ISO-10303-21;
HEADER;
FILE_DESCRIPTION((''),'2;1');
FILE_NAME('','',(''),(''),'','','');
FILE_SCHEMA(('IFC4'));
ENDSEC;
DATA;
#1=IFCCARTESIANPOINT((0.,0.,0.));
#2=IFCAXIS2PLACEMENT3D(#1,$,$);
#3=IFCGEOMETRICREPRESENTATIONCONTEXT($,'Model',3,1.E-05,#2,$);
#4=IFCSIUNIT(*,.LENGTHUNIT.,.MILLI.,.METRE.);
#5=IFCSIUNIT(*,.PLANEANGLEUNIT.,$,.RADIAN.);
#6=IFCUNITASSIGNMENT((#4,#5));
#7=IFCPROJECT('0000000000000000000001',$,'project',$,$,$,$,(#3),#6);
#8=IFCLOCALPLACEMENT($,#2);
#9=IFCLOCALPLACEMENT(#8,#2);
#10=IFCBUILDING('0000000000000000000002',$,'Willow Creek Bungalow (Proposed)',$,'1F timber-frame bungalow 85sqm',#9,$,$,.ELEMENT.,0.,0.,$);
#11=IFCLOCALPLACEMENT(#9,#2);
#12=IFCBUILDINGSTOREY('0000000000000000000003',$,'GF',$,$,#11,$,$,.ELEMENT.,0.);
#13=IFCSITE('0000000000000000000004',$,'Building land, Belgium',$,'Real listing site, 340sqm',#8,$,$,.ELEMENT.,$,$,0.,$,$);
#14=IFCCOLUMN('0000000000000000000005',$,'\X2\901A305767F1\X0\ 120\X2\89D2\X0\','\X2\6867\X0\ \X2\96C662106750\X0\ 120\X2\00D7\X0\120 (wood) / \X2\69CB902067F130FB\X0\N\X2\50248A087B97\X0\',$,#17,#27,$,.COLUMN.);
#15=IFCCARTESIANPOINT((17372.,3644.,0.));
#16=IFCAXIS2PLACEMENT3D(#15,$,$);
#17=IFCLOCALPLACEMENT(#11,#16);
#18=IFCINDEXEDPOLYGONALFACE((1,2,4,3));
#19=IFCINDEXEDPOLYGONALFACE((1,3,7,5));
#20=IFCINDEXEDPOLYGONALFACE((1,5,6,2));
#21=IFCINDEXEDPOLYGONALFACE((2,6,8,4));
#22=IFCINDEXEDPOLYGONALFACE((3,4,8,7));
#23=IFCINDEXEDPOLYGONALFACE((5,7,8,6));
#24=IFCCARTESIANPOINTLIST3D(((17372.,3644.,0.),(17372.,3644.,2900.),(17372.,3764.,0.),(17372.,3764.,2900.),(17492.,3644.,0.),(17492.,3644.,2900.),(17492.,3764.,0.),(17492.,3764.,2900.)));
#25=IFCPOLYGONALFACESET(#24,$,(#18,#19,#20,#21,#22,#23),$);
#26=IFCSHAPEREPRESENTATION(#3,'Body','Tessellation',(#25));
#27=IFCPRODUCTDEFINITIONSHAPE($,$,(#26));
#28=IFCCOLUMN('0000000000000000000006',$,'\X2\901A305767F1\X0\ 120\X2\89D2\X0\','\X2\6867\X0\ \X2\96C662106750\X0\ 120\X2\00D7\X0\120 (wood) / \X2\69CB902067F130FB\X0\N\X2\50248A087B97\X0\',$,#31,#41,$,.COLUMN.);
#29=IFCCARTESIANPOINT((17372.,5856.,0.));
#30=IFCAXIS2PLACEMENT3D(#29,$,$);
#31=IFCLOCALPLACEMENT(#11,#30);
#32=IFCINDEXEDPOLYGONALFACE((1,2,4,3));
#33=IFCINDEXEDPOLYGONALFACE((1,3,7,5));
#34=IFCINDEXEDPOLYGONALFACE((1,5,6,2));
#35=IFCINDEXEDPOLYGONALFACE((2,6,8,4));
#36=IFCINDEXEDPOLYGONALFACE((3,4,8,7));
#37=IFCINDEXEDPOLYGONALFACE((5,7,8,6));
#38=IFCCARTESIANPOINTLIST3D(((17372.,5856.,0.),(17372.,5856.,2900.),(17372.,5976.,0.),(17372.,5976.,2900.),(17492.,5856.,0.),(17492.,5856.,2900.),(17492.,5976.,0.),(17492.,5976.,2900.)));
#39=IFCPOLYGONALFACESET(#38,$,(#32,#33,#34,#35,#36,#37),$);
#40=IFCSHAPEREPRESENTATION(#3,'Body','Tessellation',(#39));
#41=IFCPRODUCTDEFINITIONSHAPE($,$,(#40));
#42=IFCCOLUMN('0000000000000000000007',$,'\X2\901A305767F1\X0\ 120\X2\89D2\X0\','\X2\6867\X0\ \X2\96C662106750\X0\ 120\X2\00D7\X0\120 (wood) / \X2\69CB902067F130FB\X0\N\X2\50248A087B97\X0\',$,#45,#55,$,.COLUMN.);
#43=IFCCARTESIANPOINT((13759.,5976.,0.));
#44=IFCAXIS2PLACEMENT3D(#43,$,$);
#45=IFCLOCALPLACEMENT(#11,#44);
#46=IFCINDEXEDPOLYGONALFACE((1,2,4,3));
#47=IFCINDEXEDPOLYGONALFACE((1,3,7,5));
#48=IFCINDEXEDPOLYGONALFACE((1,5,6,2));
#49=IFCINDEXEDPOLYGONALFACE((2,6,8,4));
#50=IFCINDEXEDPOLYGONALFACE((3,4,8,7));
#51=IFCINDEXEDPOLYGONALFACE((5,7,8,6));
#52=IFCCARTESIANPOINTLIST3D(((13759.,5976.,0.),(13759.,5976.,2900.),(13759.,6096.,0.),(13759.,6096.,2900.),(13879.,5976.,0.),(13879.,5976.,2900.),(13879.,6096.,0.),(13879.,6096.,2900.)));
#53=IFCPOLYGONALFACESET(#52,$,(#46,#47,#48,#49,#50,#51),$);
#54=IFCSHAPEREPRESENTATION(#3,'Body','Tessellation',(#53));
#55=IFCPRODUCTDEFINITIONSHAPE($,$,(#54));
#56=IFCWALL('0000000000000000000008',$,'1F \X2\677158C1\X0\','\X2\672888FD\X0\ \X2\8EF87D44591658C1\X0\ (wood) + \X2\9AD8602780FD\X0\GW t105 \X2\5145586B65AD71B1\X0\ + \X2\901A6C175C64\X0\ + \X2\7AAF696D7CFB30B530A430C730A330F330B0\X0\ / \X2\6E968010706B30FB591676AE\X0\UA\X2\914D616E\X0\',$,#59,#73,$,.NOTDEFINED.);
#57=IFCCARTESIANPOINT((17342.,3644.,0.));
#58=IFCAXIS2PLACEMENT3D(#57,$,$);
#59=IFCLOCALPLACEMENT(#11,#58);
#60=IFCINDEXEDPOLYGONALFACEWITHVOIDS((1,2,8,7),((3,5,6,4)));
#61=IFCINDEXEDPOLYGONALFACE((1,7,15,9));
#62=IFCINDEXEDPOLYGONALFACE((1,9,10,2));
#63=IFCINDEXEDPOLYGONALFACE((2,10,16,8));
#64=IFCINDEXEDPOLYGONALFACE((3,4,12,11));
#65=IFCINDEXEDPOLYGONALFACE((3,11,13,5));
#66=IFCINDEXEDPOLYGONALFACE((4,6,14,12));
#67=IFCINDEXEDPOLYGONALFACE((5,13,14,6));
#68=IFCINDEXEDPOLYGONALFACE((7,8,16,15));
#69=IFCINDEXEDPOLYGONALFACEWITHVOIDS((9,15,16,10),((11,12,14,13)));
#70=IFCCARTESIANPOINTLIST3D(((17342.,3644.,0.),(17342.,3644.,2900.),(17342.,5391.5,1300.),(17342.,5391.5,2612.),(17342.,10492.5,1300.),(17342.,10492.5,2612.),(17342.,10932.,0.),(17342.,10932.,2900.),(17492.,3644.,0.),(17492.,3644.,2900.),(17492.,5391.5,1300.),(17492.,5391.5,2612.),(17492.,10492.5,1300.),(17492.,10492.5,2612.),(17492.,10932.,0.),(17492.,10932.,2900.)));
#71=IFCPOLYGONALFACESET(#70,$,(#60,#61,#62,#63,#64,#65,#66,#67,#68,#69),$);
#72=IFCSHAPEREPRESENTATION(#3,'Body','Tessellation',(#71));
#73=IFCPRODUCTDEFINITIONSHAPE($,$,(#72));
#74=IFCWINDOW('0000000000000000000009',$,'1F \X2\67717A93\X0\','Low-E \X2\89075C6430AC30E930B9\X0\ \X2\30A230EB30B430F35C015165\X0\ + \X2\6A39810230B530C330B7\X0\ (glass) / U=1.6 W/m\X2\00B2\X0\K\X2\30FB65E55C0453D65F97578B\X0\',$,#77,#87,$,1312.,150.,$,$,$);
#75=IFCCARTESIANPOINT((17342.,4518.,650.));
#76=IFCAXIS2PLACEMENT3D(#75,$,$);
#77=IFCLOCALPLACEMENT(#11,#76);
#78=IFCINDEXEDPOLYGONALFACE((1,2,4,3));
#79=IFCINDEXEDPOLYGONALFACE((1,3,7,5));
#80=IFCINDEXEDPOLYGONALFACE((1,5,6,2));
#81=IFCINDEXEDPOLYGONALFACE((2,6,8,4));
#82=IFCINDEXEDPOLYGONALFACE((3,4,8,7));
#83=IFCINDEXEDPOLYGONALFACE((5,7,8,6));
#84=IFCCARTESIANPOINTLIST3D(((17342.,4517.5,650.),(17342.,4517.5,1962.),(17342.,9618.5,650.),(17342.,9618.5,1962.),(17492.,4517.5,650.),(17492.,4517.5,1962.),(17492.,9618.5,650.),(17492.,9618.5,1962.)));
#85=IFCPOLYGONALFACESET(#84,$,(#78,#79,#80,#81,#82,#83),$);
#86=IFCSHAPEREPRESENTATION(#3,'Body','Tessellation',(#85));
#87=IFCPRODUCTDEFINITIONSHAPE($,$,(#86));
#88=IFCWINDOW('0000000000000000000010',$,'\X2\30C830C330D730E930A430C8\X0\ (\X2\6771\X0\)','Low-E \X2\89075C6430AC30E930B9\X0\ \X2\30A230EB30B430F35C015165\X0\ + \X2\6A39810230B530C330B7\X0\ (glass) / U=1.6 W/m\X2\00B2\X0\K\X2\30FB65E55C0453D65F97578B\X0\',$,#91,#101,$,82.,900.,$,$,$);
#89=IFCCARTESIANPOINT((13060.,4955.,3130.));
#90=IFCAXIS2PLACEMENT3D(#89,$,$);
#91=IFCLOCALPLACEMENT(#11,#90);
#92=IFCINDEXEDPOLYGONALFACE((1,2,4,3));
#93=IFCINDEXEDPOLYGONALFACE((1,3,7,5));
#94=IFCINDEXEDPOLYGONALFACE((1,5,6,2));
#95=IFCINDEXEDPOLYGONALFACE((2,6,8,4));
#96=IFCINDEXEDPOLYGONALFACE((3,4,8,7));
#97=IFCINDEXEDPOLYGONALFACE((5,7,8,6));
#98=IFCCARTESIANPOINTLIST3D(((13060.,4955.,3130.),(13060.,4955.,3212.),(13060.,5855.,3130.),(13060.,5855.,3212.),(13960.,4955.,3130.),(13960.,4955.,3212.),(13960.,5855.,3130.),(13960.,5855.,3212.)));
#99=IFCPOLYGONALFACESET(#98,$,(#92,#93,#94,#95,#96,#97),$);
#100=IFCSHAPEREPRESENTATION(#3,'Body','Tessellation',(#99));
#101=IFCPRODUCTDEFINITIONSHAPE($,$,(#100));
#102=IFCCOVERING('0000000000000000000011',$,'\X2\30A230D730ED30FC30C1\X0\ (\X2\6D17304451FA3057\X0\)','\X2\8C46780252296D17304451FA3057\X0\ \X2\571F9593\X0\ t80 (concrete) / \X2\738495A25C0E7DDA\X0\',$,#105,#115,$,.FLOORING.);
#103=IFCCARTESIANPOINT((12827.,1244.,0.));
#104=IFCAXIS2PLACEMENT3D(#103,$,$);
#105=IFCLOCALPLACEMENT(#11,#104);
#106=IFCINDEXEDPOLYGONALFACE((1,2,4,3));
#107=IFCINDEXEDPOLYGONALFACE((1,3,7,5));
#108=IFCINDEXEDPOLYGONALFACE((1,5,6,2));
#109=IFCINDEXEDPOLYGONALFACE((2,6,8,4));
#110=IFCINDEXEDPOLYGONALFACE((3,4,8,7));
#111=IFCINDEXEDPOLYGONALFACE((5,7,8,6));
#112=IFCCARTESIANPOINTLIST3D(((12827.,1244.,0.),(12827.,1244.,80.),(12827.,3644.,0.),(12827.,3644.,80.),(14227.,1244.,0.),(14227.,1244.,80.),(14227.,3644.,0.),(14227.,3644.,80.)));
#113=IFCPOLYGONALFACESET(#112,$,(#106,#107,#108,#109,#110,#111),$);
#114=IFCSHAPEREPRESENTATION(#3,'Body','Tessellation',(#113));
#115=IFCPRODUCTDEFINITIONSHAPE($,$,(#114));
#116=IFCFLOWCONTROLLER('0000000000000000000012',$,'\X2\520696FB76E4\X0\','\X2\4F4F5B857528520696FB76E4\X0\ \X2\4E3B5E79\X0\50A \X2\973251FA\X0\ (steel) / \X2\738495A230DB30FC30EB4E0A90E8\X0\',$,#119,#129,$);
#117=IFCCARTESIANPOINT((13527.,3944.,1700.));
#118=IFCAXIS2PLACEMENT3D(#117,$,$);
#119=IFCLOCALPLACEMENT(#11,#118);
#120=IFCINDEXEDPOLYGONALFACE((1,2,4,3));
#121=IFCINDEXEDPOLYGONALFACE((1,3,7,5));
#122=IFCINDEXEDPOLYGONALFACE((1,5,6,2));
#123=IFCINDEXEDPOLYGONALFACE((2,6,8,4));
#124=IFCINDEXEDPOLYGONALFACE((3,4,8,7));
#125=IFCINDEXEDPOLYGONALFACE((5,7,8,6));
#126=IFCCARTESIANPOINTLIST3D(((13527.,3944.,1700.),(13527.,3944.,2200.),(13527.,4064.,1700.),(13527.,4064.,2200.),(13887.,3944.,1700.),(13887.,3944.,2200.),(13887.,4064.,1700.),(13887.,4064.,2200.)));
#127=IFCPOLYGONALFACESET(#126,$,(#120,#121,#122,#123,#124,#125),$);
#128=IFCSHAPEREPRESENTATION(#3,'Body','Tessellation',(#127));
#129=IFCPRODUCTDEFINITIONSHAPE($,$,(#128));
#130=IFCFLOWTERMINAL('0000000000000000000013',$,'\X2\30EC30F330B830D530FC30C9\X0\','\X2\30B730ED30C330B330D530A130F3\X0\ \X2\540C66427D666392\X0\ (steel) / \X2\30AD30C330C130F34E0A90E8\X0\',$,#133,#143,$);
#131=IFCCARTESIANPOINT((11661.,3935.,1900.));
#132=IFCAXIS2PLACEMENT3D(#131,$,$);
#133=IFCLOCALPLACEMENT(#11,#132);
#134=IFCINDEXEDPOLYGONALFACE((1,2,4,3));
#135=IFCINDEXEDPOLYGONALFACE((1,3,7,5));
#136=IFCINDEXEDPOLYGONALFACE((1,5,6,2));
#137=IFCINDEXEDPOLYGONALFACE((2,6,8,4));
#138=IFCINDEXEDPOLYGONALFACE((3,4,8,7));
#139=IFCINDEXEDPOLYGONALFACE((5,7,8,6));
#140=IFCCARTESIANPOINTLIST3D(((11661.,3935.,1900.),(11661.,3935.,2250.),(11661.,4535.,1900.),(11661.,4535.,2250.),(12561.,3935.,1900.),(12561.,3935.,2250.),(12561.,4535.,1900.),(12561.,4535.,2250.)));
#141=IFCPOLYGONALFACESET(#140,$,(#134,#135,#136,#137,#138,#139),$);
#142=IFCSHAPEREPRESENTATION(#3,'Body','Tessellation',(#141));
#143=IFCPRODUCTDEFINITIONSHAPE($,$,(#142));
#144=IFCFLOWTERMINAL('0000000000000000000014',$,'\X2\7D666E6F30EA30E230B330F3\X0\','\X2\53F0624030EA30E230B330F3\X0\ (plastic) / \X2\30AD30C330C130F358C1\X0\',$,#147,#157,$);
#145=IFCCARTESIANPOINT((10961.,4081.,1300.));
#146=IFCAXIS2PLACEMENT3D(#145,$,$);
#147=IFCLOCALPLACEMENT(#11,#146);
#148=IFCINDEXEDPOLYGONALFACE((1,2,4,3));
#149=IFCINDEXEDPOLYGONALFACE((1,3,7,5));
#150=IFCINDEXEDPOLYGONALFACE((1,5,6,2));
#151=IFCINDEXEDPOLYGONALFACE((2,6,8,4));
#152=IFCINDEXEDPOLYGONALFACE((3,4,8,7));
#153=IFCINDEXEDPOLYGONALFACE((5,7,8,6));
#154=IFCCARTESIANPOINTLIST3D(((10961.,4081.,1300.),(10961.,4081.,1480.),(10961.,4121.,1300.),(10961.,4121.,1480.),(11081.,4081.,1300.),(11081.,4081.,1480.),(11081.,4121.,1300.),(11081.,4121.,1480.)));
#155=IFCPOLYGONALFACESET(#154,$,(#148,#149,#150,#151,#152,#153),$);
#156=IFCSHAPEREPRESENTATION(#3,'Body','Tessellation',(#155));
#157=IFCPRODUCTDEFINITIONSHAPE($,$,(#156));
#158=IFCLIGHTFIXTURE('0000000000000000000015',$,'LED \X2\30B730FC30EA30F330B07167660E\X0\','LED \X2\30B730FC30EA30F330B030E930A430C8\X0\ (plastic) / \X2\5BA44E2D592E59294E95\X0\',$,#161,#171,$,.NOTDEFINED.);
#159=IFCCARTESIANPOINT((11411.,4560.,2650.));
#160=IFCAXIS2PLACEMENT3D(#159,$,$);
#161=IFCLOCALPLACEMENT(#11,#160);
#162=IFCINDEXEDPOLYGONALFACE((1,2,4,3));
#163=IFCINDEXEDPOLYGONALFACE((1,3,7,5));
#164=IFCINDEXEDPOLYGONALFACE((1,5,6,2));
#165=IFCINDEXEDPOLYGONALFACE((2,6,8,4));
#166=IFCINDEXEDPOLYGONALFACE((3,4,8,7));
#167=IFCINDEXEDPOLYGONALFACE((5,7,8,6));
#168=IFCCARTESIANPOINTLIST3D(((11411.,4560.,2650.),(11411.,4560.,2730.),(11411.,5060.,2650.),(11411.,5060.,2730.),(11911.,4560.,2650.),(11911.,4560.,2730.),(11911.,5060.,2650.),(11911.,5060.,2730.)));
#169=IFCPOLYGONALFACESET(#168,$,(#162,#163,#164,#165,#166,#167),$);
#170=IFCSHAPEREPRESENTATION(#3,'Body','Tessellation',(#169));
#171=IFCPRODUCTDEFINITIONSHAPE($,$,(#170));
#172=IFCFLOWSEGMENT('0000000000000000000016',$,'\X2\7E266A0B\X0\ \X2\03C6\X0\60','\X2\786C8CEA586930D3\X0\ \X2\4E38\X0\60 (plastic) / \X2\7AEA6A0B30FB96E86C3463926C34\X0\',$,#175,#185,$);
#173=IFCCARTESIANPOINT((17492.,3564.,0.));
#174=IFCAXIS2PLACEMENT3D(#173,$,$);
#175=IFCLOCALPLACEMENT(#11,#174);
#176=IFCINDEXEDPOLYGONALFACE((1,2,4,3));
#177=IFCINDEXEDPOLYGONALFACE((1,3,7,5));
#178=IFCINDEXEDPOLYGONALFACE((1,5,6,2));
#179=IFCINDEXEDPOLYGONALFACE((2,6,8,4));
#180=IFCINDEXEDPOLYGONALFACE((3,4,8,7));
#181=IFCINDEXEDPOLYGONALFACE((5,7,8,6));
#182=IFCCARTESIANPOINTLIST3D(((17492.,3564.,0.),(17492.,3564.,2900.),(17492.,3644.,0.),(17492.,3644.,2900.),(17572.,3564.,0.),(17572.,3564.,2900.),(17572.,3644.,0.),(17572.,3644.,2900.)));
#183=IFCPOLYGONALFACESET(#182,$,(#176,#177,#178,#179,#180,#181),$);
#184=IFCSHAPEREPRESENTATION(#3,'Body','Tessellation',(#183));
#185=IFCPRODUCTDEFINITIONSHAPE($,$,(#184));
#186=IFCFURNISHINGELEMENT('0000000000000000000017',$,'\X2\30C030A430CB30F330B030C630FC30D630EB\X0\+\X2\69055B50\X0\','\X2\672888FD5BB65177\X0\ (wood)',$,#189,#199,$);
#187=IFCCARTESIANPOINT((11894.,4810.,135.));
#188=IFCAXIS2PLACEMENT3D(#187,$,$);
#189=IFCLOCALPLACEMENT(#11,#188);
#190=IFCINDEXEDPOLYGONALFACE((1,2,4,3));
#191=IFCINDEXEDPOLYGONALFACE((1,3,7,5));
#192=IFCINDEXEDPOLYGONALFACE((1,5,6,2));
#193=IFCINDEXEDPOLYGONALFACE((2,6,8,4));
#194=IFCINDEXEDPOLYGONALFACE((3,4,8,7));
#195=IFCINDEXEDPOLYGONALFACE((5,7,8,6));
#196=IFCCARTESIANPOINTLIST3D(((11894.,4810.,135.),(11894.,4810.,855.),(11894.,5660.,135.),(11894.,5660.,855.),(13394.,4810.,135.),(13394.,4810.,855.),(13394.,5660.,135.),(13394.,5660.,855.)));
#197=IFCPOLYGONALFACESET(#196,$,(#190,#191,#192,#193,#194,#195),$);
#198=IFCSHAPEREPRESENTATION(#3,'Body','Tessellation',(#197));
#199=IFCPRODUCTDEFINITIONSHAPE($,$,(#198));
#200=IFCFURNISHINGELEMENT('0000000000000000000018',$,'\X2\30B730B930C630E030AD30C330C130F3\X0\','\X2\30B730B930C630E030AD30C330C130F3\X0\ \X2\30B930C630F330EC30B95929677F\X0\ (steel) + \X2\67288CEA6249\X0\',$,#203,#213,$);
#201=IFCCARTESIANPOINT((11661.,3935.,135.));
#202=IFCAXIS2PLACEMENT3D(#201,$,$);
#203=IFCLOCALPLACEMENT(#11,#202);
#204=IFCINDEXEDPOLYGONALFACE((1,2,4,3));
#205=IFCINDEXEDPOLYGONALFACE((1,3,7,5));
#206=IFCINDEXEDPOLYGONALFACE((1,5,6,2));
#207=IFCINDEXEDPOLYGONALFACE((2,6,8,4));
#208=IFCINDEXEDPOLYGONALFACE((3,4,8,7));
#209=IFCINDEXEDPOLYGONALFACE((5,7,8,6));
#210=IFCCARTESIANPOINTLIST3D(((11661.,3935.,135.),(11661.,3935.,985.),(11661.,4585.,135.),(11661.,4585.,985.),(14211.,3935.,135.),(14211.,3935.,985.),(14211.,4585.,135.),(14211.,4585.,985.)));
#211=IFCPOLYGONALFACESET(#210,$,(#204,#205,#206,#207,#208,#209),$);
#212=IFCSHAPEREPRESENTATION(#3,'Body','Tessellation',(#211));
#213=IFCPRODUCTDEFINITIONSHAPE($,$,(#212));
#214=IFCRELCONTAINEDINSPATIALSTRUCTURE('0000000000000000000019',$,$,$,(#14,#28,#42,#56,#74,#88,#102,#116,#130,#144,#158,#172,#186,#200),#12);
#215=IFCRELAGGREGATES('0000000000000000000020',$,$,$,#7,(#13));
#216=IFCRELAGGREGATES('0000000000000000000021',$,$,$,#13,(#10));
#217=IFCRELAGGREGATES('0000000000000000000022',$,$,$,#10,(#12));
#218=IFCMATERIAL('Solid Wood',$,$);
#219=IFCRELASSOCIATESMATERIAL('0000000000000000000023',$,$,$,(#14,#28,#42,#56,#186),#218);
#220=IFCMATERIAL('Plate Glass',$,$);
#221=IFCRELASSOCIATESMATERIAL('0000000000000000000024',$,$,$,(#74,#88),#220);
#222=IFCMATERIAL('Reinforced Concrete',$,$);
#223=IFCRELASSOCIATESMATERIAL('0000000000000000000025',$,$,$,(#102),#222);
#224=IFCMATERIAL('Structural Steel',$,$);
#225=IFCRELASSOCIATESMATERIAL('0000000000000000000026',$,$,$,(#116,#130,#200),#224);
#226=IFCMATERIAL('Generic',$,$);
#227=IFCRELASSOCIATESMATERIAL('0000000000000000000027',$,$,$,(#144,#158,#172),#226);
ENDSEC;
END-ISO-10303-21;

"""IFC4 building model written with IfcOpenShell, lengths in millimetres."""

from ifc_helpers import new_model, si_unit, frame, frame_2d, origin, place, context, project, spatial, rectangle, extrude, material, element, fill, save


model = new_model("IFC4")

# Units and contexts
model_context = context("Model", 3, precision=1e-05, world=origin())
ifc_project = project(units=[si_unit("LENGTHUNIT", "METRE", prefix="MILLI"), si_unit("PLANEANGLEUNIT", "RADIAN")], contexts=[model_context])

# Site, building, storey
site_placement = place(None, origin())
site = spatial("IfcSite", under=ifc_project, at=site_placement, Name="Building land, Belgium", ObjectType="Real listing site, 340sqm", CompositionType="ELEMENT", RefElevation=0.0)
building_placement = place(site_placement, origin())
building = spatial("IfcBuilding", under=site, at=building_placement, Name="Willow Creek Bungalow (Proposed)", ObjectType="1F timber-frame bungalow 85sqm", CompositionType="ELEMENT", ElevationOfRefHeight=0.0, ElevationOfTerrain=0.0)
storey_placement = place(building_placement, origin())
storey = spatial("IfcBuildingStorey", under=building, at=storey_placement, Name="GF", CompositionType="ELEMENT", Elevation=0.0)

# Columns
ifc_material_1 = material(Name="Solid Wood")
column_1_placement = place(storey_placement, frame((17372.0, 3644.0, 0.0)))
element("IfcColumn", 1, at=column_1_placement, inside=storey, material=ifc_material_1, Name="通し柱 120角", Description="桧 集成材 120×120 (wood) / 構造柱・N値計算", PredefinedType="COLUMN", context=model_context, shape_type="SweptSolid", body=[
    extrude(rectangle(XDim=120.0, YDim=120.0, at=frame_2d((60.0, 60.0))), frame((17372.0, 3644.0, 0.0)), (0.0, 0.0, 1.0), 2900.0),
])
column_2_placement = place(storey_placement, frame((17372.0, 5856.0, 0.0)))
element("IfcColumn", 2, at=column_2_placement, inside=storey, material=ifc_material_1, Name="通し柱 120角", Description="桧 集成材 120×120 (wood) / 構造柱・N値計算", PredefinedType="COLUMN", context=model_context, shape_type="SweptSolid", body=[
    extrude(rectangle(XDim=120.0, YDim=120.0, at=frame_2d((60.0, 60.0))), frame((17372.0, 5856.0, 0.0)), (0.0, 0.0, 1.0), 2900.0),
])
column_3_placement = place(storey_placement, frame((13759.0, 5976.0, 0.0)))
element("IfcColumn", 3, at=column_3_placement, inside=storey, material=ifc_material_1, Name="通し柱 120角", Description="桧 集成材 120×120 (wood) / 構造柱・N値計算", PredefinedType="COLUMN", context=model_context, shape_type="SweptSolid", body=[
    extrude(rectangle(XDim=120.0, YDim=120.0, at=frame_2d((60.0, 60.0))), frame((13759.0, 5976.0, 0.0)), (0.0, 0.0, 1.0), 2900.0),
])

# Wall, opening, window
wall_1_placement = place(storey_placement, frame((17342.0, 3644.0, 0.0)))
wall_1 = element("IfcWall", 4, at=wall_1_placement, inside=storey, material=ifc_material_1, Name="1F 東壁", Description="木製 軸組外壁 (wood) + 高性能GW t105 充填断熱 + 通気層 + 窯業系サイディング / 準耐火・外皮UA配慮", PredefinedType="NOTDEFINED", context=model_context, shape_type="SweptSolid", body=[
    extrude(rectangle(XDim=150.0, YDim=7288.0, at=frame_2d((75.0, 3644.0))), frame((17342.0, 3644.0, 0.0)), (0.0, 0.0, 1.0), 2900.0),
])
opening_1_placement = place(storey_placement, frame((17342.0, 4518.0, 650.0)))
opening_1 = element("IfcOpeningElement", 5, at=opening_1_placement, cuts=wall_1, PredefinedType="NOTDEFINED", context=model_context, shape_type="SweptSolid", body=[
    extrude(rectangle(XDim=150.0, YDim=5101.0, at=frame_2d((75.0, 2550.0))), frame((17342.0, 4518.0, 650.0)), (0.0, 0.0, 1.0), 1312.0),
])
ifc_material_2 = material(Name="Plate Glass")
window_1_placement = place(storey_placement, frame((17342.0, 4518.0, 650.0)))
window_1 = element("IfcWindow", 6, at=window_1_placement, inside=storey, material=ifc_material_2, Name="1F 東窓", Description="Low-E 複層ガラス アルゴン封入 + 樹脂サッシ (glass) / U=1.6 W/m²K・日射取得型", OverallHeight=1312.0, OverallWidth=150.0, context=model_context, shape_type="SweptSolid", body=[
    extrude(rectangle(XDim=150.0, YDim=5101.0, at=frame_2d((75.0, 2550.0))), frame((17342.0, 4518.0, 650.0)), (0.0, 0.0, 1.0), 1312.0),
])
fill(opening_1, window_1)

# Window
window_2_placement = place(storey_placement, frame((13060.0, 4955.0, 3130.0)))
element("IfcWindow", 7, at=window_2_placement, inside=storey, material=ifc_material_2, Name="トップライト (東)", Description="Low-E 複層ガラス アルゴン封入 + 樹脂サッシ (glass) / U=1.6 W/m²K・日射取得型", OverallHeight=82.0, OverallWidth=900.0, context=model_context, shape_type="SweptSolid", body=[
    extrude(rectangle(XDim=900.0, YDim=900.0, at=frame_2d((450.0, 450.0))), frame((13060.0, 4955.0, 3130.0)), (0.0, 0.0, 1.0), 82.0),
])

# Shared definitions
ifc_material_3 = material(Name="Structural Steel")

# Covering
ifc_material_4 = material(Name="Reinforced Concrete")
covering_placement = place(storey_placement, frame((12827.0, 1244.0, 0.0)))
element("IfcCovering", 8, at=covering_placement, inside=storey, material=ifc_material_4, Name="アプローチ (洗い出し)", Description="豆砂利洗い出し 土間 t80 (concrete) / 玄関導線", PredefinedType="FLOORING", context=model_context, shape_type="SweptSolid", body=[
    extrude(rectangle(XDim=1400.0, YDim=2400.0, at=frame_2d((700.0, 1200.0))), frame((12827.0, 1244.0, 0.0)), (0.0, 0.0, 1.0), 80.0),
])

# Flow controller
flow_controller_placement = place(storey_placement, frame((13527.0, 3944.0, 1700.0)))
element("IfcFlowController", 9, at=flow_controller_placement, inside=storey, material=ifc_material_3, Name="分電盤", Description="住宅用分電盤 主幹50A 露出 (steel) / 玄関ホール上部", context=model_context, shape_type="SweptSolid", body=[
    extrude(rectangle(XDim=360.0, YDim=120.0, at=frame_2d((180.0, 60.0))), frame((13527.0, 3944.0, 1700.0)), (0.0, 0.0, 1.0), 500.0),
])

# Flow terminals
flow_terminal_1_placement = place(storey_placement, frame((11661.0, 3935.0, 1900.0)))
element("IfcFlowTerminal", 10, at=flow_terminal_1_placement, inside=storey, material=ifc_material_3, Name="レンジフード", Description="シロッコファン 同時給排 (steel) / キッチン上部", context=model_context, shape_type="SweptSolid", body=[
    extrude(rectangle(XDim=900.0, YDim=600.0, at=frame_2d((450.0, 300.0))), frame((11661.0, 3935.0, 1900.0)), (0.0, 0.0, 1.0), 350.0),
])
ifc_material_5 = material(Name="Generic")
flow_terminal_2_placement = place(storey_placement, frame((10961.0, 4081.0, 1300.0)))
element("IfcFlowTerminal", 11, at=flow_terminal_2_placement, inside=storey, material=ifc_material_5, Name="給湯リモコン", Description="台所リモコン (plastic) / キッチン壁", context=model_context, shape_type="SweptSolid", body=[
    extrude(rectangle(XDim=120.0, YDim=40.0, at=frame_2d((60.0, 20.0))), frame((10961.0, 4081.0, 1300.0)), (0.0, 0.0, 1.0), 180.0),
])

# Light fixture
light_fixture_placement = place(storey_placement, frame((11411.0, 4560.0, 2650.0)))
element("IfcLightFixture", 12, at=light_fixture_placement, inside=storey, material=ifc_material_5, Name="LED シーリング照明", Description="LED シーリングライト (plastic) / 室中央天井", PredefinedType="NOTDEFINED", context=model_context, shape_type="SweptSolid", body=[
    extrude(rectangle(XDim=500.0, YDim=500.0, at=frame_2d((250.0, 250.0))), frame((11411.0, 4560.0, 2650.0)), (0.0, 0.0, 1.0), 80.0),
])

# Flow segment
flow_segment_placement = place(storey_placement, frame((17492.0, 3564.0, 0.0)))
element("IfcFlowSegment", 13, at=flow_segment_placement, inside=storey, material=ifc_material_5, Name="縦樋 φ60", Description="硬質塩ビ 丸60 (plastic) / 竪樋・雨水排水", context=model_context, shape_type="SweptSolid", body=[
    extrude(rectangle(XDim=80.0, YDim=80.0, at=frame_2d((40.0, 40.0))), frame((17492.0, 3564.0, 0.0)), (0.0, 0.0, 1.0), 2900.0),
])

# Furnishing elements
furnishing_1_placement = place(storey_placement, frame((11894.0, 4810.0, 135.0)))
element("IfcFurnishingElement", 14, at=furnishing_1_placement, inside=storey, material=ifc_material_1, Name="ダイニングテーブル+椅子", Description="木製家具 (wood)", context=model_context, shape_type="SweptSolid", body=[
    extrude(rectangle(XDim=1500.0, YDim=850.0, at=frame_2d((750.0, 425.0))), frame((11894.0, 4810.0, 135.0)), (0.0, 0.0, 1.0), 720.0),
])
furnishing_2_placement = place(storey_placement, frame((11661.0, 3935.0, 135.0)))
element("IfcFurnishingElement", 15, at=furnishing_2_placement, inside=storey, material=ifc_material_3, Name="システムキッチン", Description="システムキッチン ステンレス天板 (steel) + 木質扉", context=model_context, shape_type="SweptSolid", body=[
    extrude(rectangle(XDim=2550.0, YDim=650.0, at=frame_2d((1275.0, 325.0))), frame((11661.0, 3935.0, 135.0)), (0.0, 0.0, 1.0), 850.0),
])

save(model, "model.ifc")
